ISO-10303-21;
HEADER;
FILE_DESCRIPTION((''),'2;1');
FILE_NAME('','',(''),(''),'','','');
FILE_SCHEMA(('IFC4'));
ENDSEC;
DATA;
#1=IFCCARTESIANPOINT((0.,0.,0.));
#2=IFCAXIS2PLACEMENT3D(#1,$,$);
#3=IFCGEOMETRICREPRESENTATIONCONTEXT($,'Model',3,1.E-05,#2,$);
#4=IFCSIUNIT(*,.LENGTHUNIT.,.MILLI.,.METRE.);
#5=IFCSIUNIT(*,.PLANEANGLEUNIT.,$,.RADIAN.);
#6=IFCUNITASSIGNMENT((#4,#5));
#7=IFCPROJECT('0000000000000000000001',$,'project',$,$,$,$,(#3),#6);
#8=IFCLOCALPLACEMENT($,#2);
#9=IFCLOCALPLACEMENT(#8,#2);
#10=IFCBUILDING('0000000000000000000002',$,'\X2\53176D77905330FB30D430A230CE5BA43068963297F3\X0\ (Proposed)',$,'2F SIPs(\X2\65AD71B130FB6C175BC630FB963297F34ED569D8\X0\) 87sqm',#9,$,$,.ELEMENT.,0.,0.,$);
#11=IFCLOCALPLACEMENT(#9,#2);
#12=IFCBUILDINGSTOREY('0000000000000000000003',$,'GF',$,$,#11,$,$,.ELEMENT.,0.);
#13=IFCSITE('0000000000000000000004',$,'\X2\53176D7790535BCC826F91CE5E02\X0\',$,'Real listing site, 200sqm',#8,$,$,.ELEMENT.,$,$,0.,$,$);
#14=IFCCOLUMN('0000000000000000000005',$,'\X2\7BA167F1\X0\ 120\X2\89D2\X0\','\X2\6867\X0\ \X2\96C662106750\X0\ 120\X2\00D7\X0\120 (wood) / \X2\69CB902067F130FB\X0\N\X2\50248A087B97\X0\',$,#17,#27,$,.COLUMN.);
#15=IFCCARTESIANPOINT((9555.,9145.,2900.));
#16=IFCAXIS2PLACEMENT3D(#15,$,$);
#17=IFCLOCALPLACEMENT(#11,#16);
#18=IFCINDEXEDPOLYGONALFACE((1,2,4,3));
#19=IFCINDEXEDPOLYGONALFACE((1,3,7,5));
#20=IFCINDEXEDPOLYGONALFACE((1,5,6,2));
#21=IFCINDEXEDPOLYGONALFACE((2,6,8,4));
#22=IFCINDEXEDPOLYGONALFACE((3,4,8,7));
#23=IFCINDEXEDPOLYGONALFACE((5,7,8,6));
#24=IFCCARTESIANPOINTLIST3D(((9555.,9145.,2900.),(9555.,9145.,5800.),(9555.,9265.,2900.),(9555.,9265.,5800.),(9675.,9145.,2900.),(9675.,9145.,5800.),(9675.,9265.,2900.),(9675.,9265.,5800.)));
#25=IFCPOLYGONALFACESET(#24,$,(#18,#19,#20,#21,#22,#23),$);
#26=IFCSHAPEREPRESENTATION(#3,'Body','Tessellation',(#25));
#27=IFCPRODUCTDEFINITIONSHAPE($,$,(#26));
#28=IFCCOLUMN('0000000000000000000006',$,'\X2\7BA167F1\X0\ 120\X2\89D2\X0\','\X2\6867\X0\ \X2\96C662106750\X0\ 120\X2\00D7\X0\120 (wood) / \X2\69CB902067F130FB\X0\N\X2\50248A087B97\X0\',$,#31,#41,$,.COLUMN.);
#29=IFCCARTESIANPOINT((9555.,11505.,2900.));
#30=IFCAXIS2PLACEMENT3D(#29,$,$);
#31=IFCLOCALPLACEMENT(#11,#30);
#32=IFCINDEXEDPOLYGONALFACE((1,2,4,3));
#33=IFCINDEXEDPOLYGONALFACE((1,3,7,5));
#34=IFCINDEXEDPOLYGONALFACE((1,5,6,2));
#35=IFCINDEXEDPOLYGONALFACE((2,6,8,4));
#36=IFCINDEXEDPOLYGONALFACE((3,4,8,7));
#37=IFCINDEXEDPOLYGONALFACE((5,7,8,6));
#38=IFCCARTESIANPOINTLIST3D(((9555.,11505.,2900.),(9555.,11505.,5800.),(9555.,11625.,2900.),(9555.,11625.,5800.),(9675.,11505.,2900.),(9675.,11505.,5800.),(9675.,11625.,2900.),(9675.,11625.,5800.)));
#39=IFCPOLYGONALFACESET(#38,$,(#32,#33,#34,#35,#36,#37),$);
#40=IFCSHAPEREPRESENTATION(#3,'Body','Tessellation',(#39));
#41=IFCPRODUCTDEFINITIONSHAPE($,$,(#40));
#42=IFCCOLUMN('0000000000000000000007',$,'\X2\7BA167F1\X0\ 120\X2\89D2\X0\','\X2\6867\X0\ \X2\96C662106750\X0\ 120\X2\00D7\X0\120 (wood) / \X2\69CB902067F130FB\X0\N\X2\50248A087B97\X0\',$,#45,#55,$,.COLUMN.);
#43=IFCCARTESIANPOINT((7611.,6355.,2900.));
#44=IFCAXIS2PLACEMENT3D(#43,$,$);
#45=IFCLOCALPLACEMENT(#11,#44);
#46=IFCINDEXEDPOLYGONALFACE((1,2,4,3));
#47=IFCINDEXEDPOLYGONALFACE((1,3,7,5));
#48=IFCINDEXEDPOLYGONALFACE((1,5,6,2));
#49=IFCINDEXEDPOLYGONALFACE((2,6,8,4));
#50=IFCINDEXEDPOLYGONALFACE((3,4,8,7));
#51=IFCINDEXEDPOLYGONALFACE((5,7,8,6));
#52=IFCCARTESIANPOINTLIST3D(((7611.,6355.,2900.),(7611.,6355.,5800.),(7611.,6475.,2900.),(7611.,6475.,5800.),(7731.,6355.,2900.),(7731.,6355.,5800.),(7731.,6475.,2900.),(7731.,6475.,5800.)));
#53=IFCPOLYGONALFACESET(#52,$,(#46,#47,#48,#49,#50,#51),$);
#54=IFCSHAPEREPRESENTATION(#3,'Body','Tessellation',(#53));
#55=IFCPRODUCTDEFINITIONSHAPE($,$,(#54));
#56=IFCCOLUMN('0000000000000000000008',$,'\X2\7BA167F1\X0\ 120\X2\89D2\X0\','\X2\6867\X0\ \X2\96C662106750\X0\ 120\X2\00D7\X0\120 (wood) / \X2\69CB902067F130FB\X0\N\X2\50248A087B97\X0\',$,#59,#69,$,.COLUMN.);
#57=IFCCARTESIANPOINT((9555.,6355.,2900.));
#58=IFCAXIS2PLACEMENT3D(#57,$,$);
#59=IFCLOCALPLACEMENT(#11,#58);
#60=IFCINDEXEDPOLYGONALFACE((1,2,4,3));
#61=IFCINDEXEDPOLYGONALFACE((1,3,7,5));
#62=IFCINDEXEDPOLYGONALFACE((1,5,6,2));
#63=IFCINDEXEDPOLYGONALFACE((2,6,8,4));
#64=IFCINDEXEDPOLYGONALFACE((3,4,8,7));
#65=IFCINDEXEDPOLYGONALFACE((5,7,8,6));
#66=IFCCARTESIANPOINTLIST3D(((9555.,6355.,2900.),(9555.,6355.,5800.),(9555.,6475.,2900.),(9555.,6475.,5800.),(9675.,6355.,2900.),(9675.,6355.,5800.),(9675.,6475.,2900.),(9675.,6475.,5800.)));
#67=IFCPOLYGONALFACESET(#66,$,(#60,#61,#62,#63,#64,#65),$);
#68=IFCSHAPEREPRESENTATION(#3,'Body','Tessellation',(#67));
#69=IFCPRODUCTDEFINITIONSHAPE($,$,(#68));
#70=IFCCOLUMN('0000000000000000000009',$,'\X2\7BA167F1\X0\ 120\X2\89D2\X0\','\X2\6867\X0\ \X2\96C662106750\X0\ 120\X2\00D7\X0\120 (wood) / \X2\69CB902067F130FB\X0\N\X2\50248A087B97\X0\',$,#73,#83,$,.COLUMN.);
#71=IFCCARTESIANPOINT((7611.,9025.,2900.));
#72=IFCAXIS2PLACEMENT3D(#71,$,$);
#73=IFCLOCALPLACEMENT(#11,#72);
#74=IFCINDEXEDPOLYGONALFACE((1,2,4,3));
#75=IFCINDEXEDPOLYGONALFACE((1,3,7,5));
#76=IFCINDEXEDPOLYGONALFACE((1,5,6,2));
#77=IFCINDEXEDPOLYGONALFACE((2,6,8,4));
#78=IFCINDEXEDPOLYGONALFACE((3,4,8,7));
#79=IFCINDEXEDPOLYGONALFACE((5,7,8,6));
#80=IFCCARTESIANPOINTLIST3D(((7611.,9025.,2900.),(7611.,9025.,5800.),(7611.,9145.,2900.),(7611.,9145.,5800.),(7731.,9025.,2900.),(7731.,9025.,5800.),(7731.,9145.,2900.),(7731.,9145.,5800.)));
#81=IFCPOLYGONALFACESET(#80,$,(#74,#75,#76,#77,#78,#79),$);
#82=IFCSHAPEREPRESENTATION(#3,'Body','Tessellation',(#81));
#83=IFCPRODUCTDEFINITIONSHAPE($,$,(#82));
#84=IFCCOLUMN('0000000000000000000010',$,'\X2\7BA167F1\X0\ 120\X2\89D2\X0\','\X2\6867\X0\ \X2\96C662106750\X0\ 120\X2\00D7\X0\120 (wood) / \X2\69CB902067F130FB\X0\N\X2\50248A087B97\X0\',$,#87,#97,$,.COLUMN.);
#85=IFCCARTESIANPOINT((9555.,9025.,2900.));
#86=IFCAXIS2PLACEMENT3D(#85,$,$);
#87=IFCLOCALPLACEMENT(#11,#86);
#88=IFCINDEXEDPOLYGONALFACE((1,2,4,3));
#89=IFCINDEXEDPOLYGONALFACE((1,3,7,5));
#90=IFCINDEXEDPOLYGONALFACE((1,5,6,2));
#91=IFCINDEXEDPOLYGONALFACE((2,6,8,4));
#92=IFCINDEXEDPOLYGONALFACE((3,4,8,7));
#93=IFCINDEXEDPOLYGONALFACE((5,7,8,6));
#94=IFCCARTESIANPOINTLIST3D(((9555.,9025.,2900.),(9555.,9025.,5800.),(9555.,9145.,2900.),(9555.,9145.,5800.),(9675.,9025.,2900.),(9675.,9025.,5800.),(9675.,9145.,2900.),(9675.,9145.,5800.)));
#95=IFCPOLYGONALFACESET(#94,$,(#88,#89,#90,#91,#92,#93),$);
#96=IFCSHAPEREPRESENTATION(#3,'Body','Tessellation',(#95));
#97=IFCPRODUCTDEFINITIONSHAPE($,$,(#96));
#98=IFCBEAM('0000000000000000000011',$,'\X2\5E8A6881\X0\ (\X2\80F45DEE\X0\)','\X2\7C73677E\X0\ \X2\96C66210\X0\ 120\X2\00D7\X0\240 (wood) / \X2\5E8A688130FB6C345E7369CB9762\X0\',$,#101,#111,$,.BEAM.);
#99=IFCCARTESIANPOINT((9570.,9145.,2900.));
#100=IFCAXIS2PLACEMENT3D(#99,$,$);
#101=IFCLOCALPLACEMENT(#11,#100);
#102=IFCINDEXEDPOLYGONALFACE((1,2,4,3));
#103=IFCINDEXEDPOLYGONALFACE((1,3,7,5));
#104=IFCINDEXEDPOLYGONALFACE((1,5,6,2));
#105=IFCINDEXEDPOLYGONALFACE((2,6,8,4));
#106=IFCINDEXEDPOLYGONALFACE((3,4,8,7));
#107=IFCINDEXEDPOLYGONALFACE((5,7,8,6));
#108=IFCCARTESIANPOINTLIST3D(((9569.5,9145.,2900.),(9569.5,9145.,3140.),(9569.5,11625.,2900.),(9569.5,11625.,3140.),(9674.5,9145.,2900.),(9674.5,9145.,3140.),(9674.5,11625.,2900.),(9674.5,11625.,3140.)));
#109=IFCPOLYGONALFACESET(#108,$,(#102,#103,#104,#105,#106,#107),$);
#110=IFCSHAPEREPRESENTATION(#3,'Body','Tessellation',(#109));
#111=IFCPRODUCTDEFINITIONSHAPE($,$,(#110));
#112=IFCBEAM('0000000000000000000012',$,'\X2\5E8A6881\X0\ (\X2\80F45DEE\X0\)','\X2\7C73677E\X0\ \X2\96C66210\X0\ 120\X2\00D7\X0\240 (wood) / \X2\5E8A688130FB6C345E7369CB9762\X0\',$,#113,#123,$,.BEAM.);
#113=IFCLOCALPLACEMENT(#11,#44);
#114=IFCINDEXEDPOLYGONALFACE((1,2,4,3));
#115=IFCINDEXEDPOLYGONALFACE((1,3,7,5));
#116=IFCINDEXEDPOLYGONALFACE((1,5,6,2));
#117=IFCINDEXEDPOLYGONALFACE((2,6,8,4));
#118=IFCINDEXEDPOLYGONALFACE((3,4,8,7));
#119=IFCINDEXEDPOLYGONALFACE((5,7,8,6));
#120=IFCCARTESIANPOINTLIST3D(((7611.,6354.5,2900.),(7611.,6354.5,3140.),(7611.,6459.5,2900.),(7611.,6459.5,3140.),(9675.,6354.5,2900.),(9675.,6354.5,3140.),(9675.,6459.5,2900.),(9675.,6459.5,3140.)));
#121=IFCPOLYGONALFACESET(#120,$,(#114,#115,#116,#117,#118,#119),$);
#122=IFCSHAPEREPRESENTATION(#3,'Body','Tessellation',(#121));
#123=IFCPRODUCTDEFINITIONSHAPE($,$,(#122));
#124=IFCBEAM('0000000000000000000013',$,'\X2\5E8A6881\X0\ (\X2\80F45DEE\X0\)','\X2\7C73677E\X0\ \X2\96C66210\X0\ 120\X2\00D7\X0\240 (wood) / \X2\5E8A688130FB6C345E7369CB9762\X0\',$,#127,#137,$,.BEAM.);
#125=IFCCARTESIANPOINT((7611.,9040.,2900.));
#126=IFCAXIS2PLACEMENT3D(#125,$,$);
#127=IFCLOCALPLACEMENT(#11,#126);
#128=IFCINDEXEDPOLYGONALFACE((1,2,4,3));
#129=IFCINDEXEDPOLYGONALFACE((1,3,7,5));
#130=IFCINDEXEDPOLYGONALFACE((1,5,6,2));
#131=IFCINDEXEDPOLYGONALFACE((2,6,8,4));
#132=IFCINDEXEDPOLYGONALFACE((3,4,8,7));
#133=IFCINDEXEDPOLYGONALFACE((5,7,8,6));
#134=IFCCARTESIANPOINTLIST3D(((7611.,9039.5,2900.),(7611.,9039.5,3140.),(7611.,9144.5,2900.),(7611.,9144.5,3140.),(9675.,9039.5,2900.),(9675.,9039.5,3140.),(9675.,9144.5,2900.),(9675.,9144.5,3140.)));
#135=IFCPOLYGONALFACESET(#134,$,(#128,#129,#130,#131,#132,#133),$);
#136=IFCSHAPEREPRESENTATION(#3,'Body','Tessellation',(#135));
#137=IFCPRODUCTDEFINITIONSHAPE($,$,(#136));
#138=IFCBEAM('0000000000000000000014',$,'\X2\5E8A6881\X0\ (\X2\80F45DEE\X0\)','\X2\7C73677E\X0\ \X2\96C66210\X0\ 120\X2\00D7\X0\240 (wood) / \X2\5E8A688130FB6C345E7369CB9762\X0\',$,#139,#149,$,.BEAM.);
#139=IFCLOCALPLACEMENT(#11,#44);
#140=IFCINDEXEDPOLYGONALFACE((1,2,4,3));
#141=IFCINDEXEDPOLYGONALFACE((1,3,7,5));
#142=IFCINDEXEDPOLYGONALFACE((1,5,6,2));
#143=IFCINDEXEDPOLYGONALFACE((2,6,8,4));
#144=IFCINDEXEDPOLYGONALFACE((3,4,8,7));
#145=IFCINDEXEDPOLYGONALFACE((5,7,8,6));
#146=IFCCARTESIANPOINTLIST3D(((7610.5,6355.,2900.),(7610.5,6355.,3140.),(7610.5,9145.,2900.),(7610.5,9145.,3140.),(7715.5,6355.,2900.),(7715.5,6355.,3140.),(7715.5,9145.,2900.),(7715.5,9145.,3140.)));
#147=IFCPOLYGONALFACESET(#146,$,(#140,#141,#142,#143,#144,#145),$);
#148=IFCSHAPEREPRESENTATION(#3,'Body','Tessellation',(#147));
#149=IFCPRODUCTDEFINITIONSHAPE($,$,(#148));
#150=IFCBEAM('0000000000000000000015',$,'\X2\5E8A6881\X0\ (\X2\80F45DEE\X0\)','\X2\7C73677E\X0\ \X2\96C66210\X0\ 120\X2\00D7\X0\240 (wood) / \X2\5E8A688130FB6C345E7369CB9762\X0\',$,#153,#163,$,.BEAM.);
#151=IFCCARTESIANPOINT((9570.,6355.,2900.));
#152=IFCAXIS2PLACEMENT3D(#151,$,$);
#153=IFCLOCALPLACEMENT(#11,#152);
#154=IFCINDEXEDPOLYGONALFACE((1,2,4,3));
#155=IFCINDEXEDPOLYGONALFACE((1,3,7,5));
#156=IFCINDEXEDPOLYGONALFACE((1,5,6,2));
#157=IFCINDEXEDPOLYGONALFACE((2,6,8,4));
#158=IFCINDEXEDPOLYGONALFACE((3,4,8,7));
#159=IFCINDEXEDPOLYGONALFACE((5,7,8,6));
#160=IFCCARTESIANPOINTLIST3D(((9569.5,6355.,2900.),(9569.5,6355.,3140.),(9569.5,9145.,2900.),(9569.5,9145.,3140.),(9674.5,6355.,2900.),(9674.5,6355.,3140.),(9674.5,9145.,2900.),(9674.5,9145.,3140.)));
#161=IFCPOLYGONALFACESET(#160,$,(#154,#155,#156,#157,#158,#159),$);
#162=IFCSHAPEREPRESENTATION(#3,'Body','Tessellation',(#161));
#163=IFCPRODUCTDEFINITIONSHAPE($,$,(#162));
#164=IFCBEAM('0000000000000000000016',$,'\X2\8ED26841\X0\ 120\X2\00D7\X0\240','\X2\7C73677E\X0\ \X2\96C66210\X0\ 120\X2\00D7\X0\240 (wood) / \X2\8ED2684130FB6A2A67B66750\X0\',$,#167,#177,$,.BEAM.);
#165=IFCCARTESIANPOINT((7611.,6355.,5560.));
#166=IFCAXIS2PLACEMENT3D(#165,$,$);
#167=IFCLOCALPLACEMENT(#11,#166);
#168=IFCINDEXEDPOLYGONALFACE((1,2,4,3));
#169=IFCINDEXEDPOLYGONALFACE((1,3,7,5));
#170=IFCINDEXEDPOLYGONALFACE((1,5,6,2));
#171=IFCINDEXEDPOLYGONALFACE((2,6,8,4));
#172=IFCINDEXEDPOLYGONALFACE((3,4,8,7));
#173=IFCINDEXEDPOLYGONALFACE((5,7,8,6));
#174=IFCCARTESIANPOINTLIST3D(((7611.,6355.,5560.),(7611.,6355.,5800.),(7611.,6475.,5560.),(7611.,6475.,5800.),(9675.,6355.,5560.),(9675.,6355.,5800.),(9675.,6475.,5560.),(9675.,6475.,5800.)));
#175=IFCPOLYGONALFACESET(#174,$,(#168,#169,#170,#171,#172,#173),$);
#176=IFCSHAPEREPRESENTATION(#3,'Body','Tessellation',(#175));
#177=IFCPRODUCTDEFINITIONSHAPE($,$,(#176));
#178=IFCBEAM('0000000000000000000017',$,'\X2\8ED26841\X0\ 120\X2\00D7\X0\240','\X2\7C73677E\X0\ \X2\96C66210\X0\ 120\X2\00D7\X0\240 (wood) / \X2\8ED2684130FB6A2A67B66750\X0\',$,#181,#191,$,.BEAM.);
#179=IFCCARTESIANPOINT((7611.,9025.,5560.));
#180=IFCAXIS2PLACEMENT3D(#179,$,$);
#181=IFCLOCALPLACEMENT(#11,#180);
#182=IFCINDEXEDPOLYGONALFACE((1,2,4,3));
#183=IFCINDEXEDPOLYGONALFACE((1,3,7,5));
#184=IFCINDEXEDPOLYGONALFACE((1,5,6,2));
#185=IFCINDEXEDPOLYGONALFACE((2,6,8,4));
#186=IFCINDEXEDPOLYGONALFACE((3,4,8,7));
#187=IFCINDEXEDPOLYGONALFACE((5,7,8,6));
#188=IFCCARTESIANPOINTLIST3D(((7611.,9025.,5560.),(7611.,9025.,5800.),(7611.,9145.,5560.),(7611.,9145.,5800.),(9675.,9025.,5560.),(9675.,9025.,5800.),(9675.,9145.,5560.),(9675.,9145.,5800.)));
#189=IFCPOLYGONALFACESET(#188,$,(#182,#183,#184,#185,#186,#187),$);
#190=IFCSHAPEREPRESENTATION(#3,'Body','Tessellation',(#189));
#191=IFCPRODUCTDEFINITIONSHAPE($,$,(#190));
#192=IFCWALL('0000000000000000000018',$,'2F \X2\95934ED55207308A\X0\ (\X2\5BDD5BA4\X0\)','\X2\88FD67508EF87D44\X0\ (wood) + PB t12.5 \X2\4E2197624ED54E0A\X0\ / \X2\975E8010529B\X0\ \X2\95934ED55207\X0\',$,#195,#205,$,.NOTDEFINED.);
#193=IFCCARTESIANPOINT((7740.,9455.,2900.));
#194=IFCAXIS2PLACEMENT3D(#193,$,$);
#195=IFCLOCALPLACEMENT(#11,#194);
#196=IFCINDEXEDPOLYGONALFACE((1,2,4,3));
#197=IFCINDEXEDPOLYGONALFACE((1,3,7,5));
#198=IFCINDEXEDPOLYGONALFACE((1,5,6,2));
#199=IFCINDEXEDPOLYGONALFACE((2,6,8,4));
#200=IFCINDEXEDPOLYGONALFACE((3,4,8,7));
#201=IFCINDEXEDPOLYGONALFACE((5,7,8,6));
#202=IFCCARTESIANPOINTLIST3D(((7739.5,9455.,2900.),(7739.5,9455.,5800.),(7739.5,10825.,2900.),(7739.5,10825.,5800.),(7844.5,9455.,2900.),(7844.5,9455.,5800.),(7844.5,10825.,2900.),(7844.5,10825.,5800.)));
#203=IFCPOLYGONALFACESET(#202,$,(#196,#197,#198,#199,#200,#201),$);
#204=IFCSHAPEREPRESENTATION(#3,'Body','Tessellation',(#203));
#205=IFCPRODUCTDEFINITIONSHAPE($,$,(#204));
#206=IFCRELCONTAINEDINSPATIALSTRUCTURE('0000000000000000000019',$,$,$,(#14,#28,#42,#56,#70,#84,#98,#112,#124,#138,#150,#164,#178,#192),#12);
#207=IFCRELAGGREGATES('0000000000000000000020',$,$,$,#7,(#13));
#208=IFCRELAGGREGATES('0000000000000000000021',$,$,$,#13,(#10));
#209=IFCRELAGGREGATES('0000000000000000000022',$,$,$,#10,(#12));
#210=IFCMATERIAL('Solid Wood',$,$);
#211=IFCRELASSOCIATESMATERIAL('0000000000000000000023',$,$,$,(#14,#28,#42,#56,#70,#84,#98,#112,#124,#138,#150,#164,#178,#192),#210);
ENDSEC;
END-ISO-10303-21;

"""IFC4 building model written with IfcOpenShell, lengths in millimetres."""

from ifc_helpers import new_model, si_unit, frame, frame_2d, origin, place, context, project, spatial, rectangle, extrude, material, element, save


model = new_model("IFC4")

# Units and contexts
model_context = context("Model", 3, precision=1e-05, world=origin())
ifc_project = project(units=[si_unit("LENGTHUNIT", "METRE", prefix="MILLI"), si_unit("PLANEANGLEUNIT", "RADIAN")], contexts=[model_context])

# Site, building, storey
site_placement = place(None, origin())
site = spatial("IfcSite", under=ifc_project, at=site_placement, Name="北海道富良野市", ObjectType="Real listing site, 200sqm", CompositionType="ELEMENT", RefElevation=0.0)
building_placement = place(site_placement, origin())
building = spatial("IfcBuilding", under=site, at=building_placement, Name="北海道・ピアノ室と防音 (Proposed)", ObjectType="2F SIPs(断熱・気密・防音仕様) 87sqm", CompositionType="ELEMENT", ElevationOfRefHeight=0.0, ElevationOfTerrain=0.0)
storey_placement = place(building_placement, origin())
storey = spatial("IfcBuildingStorey", under=building, at=storey_placement, Name="GF", CompositionType="ELEMENT", Elevation=0.0)

# Columns
ifc_material_1 = material(Name="Solid Wood")
column_1_placement = place(storey_placement, frame((9555.0, 9145.0, 2900.0)))
element("IfcColumn", 1, at=column_1_placement, inside=storey, material=ifc_material_1, Name="管柱 120角", Description="桧 集成材 120×120 (wood) / 構造柱・N値計算", PredefinedType="COLUMN", context=model_context, shape_type="SweptSolid", body=[
    extrude(rectangle(XDim=120.0, YDim=120.0, at=frame_2d((60.0, 60.0))), frame((9555.0, 9145.0, 2900.0)), (0.0, 0.0, 1.0), 2900.0),
])
column_2_placement = place(storey_placement, frame((9555.0, 11505.0, 2900.0)))
element("IfcColumn", 2, at=column_2_placement, inside=storey, material=ifc_material_1, Name="管柱 120角", Description="桧 集成材 120×120 (wood) / 構造柱・N値計算", PredefinedType="COLUMN", context=model_context, shape_type="SweptSolid", body=[
    extrude(rectangle(XDim=120.0, YDim=120.0, at=frame_2d((60.0, 60.0))), frame((9555.0, 11505.0, 2900.0)), (0.0, 0.0, 1.0), 2900.0),
])
column_3_placement = place(storey_placement, frame((7611.0, 6355.0, 2900.0)))
element("IfcColumn", 3, at=column_3_placement, inside=storey, material=ifc_material_1, Name="管柱 120角", Description="桧 集成材 120×120 (wood) / 構造柱・N値計算", PredefinedType="COLUMN", context=model_context, shape_type="SweptSolid", body=[
    extrude(rectangle(XDim=120.0, YDim=120.0, at=frame_2d((60.0, 60.0))), frame((7611.0, 6355.0, 2900.0)), (0.0, 0.0, 1.0), 2900.0),
])
column_4_placement = place(storey_placement, frame((9555.0, 6355.0, 2900.0)))
element("IfcColumn", 4, at=column_4_placement, inside=storey, material=ifc_material_1, Name="管柱 120角", Description="桧 集成材 120×120 (wood) / 構造柱・N値計算", PredefinedType="COLUMN", context=model_context, shape_type="SweptSolid", body=[
    extrude(rectangle(XDim=120.0, YDim=120.0, at=frame_2d((60.0, 60.0))), frame((9555.0, 6355.0, 2900.0)), (0.0, 0.0, 1.0), 2900.0),
])
column_5_placement = place(storey_placement, frame((7611.0, 9025.0, 2900.0)))
element("IfcColumn", 5, at=column_5_placement, inside=storey, material=ifc_material_1, Name="管柱 120角", Description="桧 集成材 120×120 (wood) / 構造柱・N値計算", PredefinedType="COLUMN", context=model_context, shape_type="SweptSolid", body=[
    extrude(rectangle(XDim=120.0, YDim=120.0, at=frame_2d((60.0, 60.0))), frame((7611.0, 9025.0, 2900.0)), (0.0, 0.0, 1.0), 2900.0),
])
column_6_placement = place(storey_placement, frame((9555.0, 9025.0, 2900.0)))
element("IfcColumn", 6, at=column_6_placement, inside=storey, material=ifc_material_1, Name="管柱 120角", Description="桧 集成材 120×120 (wood) / 構造柱・N値計算", PredefinedType="COLUMN", context=model_context, shape_type="SweptSolid", body=[
    extrude(rectangle(XDim=120.0, YDim=120.0, at=frame_2d((60.0, 60.0))), frame((9555.0, 9025.0, 2900.0)), (0.0, 0.0, 1.0), 2900.0),
])

# Beams
beam_1_placement = place(storey_placement, frame((9570.0, 9145.0, 2900.0)))
element("IfcBeam", 7, at=beam_1_placement, inside=storey, material=ifc_material_1, Name="床梁 (胴差)", Description="米松 集成 120×240 (wood) / 床梁・水平構面", PredefinedType="BEAM", context=model_context, shape_type="SweptSolid", body=[
    extrude(rectangle(XDim=105.0, YDim=2480.0, at=frame_2d((52.0, 1240.0))), frame((9570.0, 9145.0, 2900.0)), (0.0, 0.0, 1.0), 240.0),
])
beam_2_placement = place(storey_placement, frame((7611.0, 6355.0, 2900.0)))
element("IfcBeam", 8, at=beam_2_placement, inside=storey, material=ifc_material_1, Name="床梁 (胴差)", Description="米松 集成 120×240 (wood) / 床梁・水平構面", PredefinedType="BEAM", context=model_context, shape_type="SweptSolid", body=[
    extrude(rectangle(XDim=2064.0, YDim=105.0, at=frame_2d((1032.0, 52.0))), frame((7611.0, 6355.0, 2900.0)), (0.0, 0.0, 1.0), 240.0),
])
beam_3_placement = place(storey_placement, frame((7611.0, 9040.0, 2900.0)))
element("IfcBeam", 9, at=beam_3_placement, inside=storey, material=ifc_material_1, Name="床梁 (胴差)", Description="米松 集成 120×240 (wood) / 床梁・水平構面", PredefinedType="BEAM", context=model_context, shape_type="SweptSolid", body=[
    extrude(rectangle(XDim=2064.0, YDim=105.0, at=frame_2d((1032.0, 52.0))), frame((7611.0, 9040.0, 2900.0)), (0.0, 0.0, 1.0), 240.0),
])
beam_4_placement = place(storey_placement, frame((7611.0, 6355.0, 2900.0)))
element("IfcBeam", 10, at=beam_4_placement, inside=storey, material=ifc_material_1, Name="床梁 (胴差)", Description="米松 集成 120×240 (wood) / 床梁・水平構面", PredefinedType="BEAM", context=model_context, shape_type="SweptSolid", body=[
    extrude(rectangle(XDim=105.0, YDim=2790.0, at=frame_2d((52.0, 1395.0))), frame((7611.0, 6355.0, 2900.0)), (0.0, 0.0, 1.0), 240.0),
])
beam_5_placement = place(storey_placement, frame((9570.0, 6355.0, 2900.0)))
element("IfcBeam", 11, at=beam_5_placement, inside=storey, material=ifc_material_1, Name="床梁 (胴差)", Description="米松 集成 120×240 (wood) / 床梁・水平構面", PredefinedType="BEAM", context=model_context, shape_type="SweptSolid", body=[
    extrude(rectangle(XDim=105.0, YDim=2790.0, at=frame_2d((52.0, 1395.0))), frame((9570.0, 6355.0, 2900.0)), (0.0, 0.0, 1.0), 240.0),
])
beam_6_placement = place(storey_placement, frame((7611.0, 6355.0, 5560.0)))
element("IfcBeam", 12, at=beam_6_placement, inside=storey, material=ifc_material_1, Name="軒桁 120×240", Description="米松 集成 120×240 (wood) / 軒桁・横架材", PredefinedType="BEAM", context=model_context, shape_type="SweptSolid", body=[
    extrude(rectangle(XDim=2064.0, YDim=120.0, at=frame_2d((1032.0, 60.0))), frame((7611.0, 6355.0, 5560.0)), (0.0, 0.0, 1.0), 240.0),
])
beam_7_placement = place(storey_placement, frame((7611.0, 9025.0, 5560.0)))
element("IfcBeam", 13, at=beam_7_placement, inside=storey, material=ifc_material_1, Name="軒桁 120×240", Description="米松 集成 120×240 (wood) / 軒桁・横架材", PredefinedType="BEAM", context=model_context, shape_type="SweptSolid", body=[
    extrude(rectangle(XDim=2064.0, YDim=120.0, at=frame_2d((1032.0, 60.0))), frame((7611.0, 9025.0, 5560.0)), (0.0, 0.0, 1.0), 240.0),
])

# Wall
wall_placement = place(storey_placement, frame((7740.0, 9455.0, 2900.0)))
element("IfcWall", 14, at=wall_placement, inside=storey, material=ifc_material_1, Name="2F 間仕切り (寝室)", Description="製材軸組 (wood) + PB t12.5 両面仕上 / 非耐力 間仕切", PredefinedType="NOTDEFINED", context=model_context, shape_type="SweptSolid", body=[
    extrude(rectangle(XDim=105.0, YDim=1370.0, at=frame_2d((52.0, 685.0))), frame((7740.0, 9455.0, 2900.0)), (0.0, 0.0, 1.0), 2900.0),
])

save(model, "model.ifc")
